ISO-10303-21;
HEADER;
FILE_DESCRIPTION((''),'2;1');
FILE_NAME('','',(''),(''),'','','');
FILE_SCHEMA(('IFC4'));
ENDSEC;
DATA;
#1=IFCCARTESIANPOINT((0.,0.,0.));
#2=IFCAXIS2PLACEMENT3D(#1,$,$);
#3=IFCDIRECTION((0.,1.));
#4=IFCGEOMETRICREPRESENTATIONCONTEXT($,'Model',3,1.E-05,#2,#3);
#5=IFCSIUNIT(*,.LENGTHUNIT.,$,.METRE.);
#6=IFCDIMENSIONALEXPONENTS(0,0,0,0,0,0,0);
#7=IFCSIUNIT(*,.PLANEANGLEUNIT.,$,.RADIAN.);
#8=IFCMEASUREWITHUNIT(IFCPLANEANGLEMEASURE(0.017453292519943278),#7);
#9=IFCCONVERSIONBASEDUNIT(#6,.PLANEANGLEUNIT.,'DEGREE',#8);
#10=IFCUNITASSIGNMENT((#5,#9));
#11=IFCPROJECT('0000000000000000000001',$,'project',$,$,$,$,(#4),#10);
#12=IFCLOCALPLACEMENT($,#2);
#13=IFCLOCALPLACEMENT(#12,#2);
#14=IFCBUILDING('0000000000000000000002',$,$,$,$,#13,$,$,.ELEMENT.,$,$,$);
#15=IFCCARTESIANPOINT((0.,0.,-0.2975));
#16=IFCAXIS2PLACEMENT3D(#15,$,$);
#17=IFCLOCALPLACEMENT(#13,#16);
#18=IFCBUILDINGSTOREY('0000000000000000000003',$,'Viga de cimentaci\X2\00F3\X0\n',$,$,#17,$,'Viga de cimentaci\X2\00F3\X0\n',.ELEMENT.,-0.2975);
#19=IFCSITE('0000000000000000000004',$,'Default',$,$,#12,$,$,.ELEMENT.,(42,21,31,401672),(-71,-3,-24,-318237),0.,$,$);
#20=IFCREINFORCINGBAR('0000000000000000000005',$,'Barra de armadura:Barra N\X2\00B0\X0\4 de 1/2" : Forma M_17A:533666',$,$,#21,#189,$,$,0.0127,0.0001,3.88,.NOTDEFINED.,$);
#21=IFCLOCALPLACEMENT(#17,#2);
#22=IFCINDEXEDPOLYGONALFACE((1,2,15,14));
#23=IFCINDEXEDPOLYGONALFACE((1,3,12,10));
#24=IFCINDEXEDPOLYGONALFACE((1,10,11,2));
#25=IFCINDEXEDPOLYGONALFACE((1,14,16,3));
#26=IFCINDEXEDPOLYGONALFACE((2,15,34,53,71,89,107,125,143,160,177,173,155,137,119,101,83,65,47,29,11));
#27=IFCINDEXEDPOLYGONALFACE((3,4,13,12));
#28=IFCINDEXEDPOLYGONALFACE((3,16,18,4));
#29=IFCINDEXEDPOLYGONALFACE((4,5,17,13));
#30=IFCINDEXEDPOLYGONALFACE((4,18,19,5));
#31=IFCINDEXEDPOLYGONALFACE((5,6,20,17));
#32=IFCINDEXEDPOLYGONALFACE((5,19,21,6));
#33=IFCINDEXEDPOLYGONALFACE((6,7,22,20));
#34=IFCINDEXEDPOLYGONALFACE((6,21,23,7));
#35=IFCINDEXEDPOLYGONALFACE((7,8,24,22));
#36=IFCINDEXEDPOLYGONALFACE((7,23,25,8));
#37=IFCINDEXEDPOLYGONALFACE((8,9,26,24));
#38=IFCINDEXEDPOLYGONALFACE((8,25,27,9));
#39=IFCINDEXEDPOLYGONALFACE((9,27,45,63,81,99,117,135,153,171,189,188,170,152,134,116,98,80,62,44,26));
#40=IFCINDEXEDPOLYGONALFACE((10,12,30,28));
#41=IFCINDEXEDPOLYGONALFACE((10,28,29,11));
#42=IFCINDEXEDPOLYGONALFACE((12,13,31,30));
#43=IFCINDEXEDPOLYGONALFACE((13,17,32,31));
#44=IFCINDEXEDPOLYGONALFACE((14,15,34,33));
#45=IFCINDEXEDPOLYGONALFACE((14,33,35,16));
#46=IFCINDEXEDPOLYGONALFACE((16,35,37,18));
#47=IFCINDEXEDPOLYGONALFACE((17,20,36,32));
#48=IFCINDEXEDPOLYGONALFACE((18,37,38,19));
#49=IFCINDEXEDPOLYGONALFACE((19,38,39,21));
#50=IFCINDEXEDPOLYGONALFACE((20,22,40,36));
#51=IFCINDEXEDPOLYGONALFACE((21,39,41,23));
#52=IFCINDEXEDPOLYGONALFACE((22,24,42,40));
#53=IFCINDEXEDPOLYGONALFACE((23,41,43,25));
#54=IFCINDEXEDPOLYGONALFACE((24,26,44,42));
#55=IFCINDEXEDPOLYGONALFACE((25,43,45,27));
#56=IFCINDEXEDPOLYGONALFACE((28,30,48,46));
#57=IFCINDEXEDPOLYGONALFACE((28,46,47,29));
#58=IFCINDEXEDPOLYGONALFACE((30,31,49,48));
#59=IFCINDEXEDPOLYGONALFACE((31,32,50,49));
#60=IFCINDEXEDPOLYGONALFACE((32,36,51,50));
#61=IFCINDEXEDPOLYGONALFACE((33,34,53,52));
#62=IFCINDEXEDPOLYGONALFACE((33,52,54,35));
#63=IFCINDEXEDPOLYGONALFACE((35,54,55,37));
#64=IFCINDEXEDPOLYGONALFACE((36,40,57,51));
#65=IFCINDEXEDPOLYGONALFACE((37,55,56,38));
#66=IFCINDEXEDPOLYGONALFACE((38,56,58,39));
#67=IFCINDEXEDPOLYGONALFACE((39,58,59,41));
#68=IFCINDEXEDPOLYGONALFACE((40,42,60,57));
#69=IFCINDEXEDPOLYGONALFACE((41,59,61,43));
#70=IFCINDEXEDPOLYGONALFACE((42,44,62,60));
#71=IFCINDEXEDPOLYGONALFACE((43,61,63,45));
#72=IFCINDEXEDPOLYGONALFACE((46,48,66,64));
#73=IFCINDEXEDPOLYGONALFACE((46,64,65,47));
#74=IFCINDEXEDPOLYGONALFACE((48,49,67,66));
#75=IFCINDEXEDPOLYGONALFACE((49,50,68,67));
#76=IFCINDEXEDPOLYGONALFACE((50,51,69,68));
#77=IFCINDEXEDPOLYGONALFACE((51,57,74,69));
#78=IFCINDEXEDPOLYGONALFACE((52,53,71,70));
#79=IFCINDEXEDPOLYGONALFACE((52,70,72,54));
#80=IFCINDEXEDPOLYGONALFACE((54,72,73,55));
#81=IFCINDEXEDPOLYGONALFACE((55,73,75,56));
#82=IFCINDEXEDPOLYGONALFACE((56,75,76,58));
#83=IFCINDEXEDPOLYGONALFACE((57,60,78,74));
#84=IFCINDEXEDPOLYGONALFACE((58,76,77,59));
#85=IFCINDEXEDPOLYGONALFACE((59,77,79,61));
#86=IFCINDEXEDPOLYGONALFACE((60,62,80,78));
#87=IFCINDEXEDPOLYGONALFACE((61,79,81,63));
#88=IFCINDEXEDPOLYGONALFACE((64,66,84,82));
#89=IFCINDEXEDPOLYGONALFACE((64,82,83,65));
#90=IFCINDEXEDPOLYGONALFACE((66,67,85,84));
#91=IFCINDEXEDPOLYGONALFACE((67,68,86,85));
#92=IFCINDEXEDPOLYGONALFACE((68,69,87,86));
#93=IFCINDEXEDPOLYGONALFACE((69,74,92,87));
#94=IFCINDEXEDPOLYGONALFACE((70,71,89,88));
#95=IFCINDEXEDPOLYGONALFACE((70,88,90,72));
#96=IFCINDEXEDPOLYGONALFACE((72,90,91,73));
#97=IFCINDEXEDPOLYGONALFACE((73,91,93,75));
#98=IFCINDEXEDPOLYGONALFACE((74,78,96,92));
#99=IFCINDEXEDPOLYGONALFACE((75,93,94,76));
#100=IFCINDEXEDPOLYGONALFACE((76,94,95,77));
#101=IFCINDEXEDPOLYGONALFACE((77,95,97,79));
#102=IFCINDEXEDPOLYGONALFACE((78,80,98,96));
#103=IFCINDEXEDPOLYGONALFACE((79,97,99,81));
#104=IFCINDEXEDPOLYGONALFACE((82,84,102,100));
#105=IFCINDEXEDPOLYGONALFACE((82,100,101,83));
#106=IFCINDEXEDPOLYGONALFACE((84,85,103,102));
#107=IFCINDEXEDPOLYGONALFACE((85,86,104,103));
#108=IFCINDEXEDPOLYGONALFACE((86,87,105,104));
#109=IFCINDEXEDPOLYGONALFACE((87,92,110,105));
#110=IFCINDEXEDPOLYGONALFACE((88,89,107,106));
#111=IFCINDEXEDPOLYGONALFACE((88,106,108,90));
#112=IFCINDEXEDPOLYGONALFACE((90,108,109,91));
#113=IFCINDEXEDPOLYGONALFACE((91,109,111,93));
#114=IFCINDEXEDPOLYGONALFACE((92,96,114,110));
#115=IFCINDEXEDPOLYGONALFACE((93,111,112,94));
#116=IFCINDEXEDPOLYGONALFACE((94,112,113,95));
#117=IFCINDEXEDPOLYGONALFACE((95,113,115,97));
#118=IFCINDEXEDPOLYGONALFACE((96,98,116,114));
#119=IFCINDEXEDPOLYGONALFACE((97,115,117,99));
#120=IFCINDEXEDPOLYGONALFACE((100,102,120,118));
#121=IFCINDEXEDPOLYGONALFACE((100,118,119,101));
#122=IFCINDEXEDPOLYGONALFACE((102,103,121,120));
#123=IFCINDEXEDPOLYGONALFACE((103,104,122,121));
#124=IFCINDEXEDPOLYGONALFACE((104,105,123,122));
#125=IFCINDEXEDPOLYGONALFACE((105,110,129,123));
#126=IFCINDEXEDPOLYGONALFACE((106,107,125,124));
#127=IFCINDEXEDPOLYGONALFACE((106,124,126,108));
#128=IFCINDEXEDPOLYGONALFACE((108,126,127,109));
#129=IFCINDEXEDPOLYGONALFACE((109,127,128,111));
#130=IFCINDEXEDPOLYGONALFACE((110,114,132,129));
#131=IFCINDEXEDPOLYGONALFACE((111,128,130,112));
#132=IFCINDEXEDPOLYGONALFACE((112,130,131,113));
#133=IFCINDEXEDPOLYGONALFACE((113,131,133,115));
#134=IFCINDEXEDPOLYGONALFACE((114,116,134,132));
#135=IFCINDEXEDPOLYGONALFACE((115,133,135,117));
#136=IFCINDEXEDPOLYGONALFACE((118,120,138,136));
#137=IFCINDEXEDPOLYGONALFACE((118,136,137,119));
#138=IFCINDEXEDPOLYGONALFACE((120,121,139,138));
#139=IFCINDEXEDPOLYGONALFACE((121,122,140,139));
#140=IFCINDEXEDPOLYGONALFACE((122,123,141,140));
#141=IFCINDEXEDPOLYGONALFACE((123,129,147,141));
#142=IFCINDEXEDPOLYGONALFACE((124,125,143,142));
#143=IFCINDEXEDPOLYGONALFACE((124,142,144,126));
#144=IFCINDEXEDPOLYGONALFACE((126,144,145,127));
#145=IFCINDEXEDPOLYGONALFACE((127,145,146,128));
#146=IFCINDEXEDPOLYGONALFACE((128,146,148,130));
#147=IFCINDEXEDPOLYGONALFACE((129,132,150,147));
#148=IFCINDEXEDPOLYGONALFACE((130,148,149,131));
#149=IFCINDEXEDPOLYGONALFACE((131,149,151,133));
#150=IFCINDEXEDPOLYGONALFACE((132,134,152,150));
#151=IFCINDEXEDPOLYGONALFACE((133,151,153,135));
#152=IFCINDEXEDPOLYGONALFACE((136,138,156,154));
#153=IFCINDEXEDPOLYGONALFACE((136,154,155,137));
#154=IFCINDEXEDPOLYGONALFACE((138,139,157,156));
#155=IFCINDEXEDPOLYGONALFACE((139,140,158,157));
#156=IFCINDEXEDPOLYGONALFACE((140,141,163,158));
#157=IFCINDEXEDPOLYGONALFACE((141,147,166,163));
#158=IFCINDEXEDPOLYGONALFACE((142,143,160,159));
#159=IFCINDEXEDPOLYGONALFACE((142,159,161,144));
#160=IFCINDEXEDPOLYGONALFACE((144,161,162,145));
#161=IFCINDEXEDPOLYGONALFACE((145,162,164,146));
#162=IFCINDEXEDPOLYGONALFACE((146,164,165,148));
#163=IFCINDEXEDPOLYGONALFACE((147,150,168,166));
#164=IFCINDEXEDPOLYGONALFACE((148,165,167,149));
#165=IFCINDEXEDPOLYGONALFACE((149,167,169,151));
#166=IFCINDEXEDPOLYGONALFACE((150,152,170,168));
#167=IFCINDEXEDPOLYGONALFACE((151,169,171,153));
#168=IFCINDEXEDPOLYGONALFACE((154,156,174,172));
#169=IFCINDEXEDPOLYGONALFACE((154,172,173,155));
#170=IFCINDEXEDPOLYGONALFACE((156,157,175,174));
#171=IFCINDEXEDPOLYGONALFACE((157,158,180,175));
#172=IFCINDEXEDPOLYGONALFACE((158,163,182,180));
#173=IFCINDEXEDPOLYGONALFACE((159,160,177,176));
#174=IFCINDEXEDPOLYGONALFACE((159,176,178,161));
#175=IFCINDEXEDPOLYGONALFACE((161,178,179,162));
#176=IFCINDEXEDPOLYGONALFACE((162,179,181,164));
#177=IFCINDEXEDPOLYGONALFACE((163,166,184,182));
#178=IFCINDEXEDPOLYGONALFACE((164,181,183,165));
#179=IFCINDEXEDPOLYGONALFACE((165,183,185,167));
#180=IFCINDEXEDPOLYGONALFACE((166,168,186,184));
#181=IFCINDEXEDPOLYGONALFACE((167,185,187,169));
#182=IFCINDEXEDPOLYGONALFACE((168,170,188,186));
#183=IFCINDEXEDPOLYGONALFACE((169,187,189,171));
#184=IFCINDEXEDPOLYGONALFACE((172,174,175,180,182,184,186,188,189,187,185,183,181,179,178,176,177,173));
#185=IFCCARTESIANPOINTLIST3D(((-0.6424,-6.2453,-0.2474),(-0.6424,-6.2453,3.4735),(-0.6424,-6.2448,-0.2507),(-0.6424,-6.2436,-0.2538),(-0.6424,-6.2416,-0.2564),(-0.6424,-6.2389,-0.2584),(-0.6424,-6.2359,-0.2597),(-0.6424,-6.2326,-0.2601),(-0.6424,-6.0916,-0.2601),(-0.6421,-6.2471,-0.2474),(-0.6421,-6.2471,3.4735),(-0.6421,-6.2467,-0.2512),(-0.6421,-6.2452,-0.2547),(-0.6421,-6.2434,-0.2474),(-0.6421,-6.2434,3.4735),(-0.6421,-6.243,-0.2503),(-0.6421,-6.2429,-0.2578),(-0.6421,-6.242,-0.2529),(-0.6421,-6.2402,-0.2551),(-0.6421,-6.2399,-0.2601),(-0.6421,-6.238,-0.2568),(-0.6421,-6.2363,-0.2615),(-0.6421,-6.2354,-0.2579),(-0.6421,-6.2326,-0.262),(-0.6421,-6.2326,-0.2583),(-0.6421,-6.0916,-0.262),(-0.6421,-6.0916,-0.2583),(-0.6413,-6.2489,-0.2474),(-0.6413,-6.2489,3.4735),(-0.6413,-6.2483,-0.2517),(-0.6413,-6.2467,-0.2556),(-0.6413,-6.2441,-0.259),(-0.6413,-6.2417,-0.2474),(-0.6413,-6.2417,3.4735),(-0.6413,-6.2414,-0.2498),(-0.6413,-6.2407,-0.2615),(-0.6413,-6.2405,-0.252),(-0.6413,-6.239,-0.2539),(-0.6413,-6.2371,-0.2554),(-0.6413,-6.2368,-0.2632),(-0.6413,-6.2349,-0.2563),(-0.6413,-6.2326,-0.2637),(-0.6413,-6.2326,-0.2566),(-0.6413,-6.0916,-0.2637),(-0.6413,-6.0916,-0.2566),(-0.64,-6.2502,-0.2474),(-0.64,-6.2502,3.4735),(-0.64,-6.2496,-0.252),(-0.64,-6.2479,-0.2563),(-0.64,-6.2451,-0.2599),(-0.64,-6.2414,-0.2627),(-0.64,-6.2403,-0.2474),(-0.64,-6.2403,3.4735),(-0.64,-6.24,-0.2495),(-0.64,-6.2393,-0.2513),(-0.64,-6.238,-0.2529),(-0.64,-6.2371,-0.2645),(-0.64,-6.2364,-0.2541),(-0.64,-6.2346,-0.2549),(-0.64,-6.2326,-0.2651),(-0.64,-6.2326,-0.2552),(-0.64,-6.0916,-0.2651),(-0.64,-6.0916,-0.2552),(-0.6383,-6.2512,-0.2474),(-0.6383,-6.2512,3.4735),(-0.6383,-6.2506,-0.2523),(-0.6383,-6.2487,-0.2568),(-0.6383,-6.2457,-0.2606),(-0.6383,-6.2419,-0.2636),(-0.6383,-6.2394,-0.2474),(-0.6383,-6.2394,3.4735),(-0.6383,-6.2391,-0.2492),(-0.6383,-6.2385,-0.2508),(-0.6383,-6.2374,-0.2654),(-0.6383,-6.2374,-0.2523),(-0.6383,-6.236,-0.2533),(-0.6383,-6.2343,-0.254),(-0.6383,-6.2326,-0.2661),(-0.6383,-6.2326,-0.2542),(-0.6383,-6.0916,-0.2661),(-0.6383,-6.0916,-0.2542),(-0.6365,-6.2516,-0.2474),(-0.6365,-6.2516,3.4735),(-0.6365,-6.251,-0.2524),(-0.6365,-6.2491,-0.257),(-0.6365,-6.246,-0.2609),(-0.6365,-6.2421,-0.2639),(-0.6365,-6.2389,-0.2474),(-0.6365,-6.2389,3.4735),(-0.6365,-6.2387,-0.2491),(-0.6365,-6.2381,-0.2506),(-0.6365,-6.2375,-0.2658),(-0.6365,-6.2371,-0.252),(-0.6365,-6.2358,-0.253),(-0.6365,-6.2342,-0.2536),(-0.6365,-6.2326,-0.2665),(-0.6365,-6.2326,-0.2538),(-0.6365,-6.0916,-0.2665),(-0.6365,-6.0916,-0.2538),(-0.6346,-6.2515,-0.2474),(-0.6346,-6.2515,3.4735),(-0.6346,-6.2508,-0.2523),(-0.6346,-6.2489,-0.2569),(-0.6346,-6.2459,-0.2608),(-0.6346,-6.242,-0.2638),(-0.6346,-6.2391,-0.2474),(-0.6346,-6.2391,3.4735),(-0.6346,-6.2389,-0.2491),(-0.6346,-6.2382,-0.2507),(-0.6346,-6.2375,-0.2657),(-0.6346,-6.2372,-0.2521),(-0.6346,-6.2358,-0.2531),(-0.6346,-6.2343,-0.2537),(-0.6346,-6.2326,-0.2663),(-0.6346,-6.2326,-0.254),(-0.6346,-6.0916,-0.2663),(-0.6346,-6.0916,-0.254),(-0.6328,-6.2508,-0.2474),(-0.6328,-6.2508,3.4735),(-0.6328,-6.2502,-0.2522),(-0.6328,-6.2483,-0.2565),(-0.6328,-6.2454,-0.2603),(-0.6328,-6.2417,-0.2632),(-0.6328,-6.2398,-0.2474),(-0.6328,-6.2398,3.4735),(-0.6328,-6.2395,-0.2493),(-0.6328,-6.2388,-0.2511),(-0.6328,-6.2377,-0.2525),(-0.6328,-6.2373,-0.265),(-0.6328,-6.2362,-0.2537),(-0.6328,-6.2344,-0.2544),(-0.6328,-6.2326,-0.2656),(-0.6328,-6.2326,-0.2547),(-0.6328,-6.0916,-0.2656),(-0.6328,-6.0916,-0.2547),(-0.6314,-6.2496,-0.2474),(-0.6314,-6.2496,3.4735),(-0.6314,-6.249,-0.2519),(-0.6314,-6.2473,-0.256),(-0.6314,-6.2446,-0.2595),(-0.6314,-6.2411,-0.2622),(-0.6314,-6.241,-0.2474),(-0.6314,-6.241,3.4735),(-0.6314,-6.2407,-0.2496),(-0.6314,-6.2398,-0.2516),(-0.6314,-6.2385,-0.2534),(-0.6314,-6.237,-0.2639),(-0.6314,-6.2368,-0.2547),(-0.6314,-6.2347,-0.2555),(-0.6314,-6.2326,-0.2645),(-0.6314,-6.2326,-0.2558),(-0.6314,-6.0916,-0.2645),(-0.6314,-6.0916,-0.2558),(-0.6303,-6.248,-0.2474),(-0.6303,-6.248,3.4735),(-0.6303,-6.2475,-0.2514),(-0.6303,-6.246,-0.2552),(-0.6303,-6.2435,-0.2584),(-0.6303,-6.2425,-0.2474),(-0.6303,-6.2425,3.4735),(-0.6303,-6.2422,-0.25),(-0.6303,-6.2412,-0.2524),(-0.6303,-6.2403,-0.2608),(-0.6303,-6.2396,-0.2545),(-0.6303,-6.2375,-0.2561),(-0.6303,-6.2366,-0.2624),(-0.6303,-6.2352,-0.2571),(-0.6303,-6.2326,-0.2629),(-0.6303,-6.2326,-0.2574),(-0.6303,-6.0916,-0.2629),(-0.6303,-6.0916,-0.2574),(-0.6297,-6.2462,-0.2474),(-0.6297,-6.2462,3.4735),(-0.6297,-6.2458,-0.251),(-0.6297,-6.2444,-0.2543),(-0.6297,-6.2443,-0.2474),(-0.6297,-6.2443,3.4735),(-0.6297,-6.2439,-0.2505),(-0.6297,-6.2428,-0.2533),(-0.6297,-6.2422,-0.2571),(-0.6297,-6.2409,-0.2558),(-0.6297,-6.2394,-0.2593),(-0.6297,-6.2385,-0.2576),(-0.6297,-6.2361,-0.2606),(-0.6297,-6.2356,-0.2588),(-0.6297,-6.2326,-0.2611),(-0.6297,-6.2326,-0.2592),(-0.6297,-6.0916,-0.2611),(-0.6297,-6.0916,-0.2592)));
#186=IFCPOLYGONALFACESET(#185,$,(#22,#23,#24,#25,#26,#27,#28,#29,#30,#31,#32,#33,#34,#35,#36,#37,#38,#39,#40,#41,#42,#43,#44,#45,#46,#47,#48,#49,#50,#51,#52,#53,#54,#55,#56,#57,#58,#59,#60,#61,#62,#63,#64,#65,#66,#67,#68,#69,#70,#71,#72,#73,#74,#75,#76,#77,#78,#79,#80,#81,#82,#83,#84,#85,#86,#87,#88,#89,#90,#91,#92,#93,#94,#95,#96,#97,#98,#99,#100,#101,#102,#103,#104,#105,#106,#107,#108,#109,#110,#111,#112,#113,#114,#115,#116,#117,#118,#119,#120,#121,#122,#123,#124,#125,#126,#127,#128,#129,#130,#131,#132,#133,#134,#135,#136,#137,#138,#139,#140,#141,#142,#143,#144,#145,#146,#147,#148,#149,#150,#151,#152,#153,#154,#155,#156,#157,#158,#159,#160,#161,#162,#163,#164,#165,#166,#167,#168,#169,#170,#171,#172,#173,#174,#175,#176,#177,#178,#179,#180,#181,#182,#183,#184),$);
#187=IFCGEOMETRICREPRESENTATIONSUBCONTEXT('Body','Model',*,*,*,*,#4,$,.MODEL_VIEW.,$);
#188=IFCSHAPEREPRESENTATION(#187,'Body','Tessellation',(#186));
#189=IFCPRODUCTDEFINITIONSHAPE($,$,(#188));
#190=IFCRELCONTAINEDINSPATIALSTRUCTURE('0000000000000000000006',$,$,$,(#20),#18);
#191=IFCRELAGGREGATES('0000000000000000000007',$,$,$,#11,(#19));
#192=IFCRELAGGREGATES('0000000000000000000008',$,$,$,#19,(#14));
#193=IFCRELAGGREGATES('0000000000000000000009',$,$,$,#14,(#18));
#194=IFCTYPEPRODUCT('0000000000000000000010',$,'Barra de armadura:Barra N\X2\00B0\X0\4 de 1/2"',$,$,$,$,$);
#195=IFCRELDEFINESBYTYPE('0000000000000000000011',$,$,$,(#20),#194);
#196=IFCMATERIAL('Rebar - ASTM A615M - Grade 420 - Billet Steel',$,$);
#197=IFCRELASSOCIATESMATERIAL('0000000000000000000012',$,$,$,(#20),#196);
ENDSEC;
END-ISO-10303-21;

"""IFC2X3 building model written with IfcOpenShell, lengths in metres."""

from ifc_helpers import new_model, entity, si_unit, converted_unit, direction, frame, origin, place, context, subcontext, project, spatial, material, type_object, element, save


model = new_model("IFC2X3")

# Units and contexts
model_context = context("Model", 3, precision=1e-05, world=origin(), true_north=direction((0.0, 1.0)))
body_context = subcontext(model_context, "Body", "Model", "MODEL_VIEW")
ifc_project = project(units=[si_unit("LENGTHUNIT", "METRE"), converted_unit("PLANEANGLEUNIT", "DEGREE", entity("IfcPlaneAngleMeasure", 0.017453292519943278), si_unit("PLANEANGLEUNIT", "RADIAN"), dimensions=[0, 0, 0, 0, 0, 0, 0])], contexts=[model_context])

# Site, building, storey
site_placement = place(None, origin())
site = spatial("IfcSite", under=ifc_project, at=site_placement, Name="Default", CompositionType="ELEMENT", RefLatitude=(42, 21, 31, 401672), RefLongitude=(-71, -3, -24, -318237), RefElevation=0.0)
building_placement = place(site_placement, origin())
building = spatial("IfcBuilding", under=site, at=building_placement, CompositionType="ELEMENT")
storey_placement = place(building_placement, frame((0.0, 0.0, -0.2975)))
storey = spatial("IfcBuildingStorey", under=building, at=storey_placement, Name="Viga de cimentación", LongName="Viga de cimentación", CompositionType="ELEMENT", Elevation=-0.2975)

# Reinforcing bar
ifc_material = material(Name="Rebar - ASTM A615M - Grade 420 - Billet Steel")
type_product_1 = type_object("IfcTypeProduct", Name="Barra de armadura:Barra N°4 de 1/2\"")
reinforcing_bar_1_placement = place(storey_placement, origin())
element("IfcReinforcingBar", 1, at=reinforcing_bar_1_placement, inside=storey, type_object=type_product_1, material=ifc_material, Name="Barra de armadura:Barra N°4 de 1/2\" : Forma M_17A:533666", BarLength=3.88, BarRole="NOTDEFINED", CrossSectionArea=0.0001, NominalDiameter=0.0127, context=body_context, shape_type="AdvancedSweptSolid", body=[
    entity("IfcSweptDiskSolid", entity("IfcCompositeCurve", [entity("IfcCompositeCurveSegment", "CONTINUOUS", True, entity("IfcPolyline", [entity("IfcCartesianPoint", [-0.636, -6.2453, 3.4735]), entity("IfcCartesianPoint", [-0.636, -6.2453, -0.2474])])), entity("IfcCompositeCurveSegment", "CONTINUOUS", True, entity("IfcTrimmedCurve", entity("IfcCircle", entity("IfcAxis2Placement3D", entity("IfcCartesianPoint", [-0.636, -6.2326, -0.2474]), entity("IfcDirection", [1.0, 0.0, 0.0]), entity("IfcDirection", [0.0, 0.0, -1.0])), 0.0127), [entity("IfcParameterValue", 270.0)], [entity("IfcParameterValue", 360.0)], True, "PARAMETER")), entity("IfcCompositeCurveSegment", "CONTINUOUS", True, entity("IfcPolyline", [entity("IfcCartesianPoint", [-0.636, -6.2326, -0.2601]), entity("IfcCartesianPoint", [-0.636, -6.0916, -0.2601])]))], False), 0.0063, None, 0.0, 92.0),
])

save(model, "model.ifc")
